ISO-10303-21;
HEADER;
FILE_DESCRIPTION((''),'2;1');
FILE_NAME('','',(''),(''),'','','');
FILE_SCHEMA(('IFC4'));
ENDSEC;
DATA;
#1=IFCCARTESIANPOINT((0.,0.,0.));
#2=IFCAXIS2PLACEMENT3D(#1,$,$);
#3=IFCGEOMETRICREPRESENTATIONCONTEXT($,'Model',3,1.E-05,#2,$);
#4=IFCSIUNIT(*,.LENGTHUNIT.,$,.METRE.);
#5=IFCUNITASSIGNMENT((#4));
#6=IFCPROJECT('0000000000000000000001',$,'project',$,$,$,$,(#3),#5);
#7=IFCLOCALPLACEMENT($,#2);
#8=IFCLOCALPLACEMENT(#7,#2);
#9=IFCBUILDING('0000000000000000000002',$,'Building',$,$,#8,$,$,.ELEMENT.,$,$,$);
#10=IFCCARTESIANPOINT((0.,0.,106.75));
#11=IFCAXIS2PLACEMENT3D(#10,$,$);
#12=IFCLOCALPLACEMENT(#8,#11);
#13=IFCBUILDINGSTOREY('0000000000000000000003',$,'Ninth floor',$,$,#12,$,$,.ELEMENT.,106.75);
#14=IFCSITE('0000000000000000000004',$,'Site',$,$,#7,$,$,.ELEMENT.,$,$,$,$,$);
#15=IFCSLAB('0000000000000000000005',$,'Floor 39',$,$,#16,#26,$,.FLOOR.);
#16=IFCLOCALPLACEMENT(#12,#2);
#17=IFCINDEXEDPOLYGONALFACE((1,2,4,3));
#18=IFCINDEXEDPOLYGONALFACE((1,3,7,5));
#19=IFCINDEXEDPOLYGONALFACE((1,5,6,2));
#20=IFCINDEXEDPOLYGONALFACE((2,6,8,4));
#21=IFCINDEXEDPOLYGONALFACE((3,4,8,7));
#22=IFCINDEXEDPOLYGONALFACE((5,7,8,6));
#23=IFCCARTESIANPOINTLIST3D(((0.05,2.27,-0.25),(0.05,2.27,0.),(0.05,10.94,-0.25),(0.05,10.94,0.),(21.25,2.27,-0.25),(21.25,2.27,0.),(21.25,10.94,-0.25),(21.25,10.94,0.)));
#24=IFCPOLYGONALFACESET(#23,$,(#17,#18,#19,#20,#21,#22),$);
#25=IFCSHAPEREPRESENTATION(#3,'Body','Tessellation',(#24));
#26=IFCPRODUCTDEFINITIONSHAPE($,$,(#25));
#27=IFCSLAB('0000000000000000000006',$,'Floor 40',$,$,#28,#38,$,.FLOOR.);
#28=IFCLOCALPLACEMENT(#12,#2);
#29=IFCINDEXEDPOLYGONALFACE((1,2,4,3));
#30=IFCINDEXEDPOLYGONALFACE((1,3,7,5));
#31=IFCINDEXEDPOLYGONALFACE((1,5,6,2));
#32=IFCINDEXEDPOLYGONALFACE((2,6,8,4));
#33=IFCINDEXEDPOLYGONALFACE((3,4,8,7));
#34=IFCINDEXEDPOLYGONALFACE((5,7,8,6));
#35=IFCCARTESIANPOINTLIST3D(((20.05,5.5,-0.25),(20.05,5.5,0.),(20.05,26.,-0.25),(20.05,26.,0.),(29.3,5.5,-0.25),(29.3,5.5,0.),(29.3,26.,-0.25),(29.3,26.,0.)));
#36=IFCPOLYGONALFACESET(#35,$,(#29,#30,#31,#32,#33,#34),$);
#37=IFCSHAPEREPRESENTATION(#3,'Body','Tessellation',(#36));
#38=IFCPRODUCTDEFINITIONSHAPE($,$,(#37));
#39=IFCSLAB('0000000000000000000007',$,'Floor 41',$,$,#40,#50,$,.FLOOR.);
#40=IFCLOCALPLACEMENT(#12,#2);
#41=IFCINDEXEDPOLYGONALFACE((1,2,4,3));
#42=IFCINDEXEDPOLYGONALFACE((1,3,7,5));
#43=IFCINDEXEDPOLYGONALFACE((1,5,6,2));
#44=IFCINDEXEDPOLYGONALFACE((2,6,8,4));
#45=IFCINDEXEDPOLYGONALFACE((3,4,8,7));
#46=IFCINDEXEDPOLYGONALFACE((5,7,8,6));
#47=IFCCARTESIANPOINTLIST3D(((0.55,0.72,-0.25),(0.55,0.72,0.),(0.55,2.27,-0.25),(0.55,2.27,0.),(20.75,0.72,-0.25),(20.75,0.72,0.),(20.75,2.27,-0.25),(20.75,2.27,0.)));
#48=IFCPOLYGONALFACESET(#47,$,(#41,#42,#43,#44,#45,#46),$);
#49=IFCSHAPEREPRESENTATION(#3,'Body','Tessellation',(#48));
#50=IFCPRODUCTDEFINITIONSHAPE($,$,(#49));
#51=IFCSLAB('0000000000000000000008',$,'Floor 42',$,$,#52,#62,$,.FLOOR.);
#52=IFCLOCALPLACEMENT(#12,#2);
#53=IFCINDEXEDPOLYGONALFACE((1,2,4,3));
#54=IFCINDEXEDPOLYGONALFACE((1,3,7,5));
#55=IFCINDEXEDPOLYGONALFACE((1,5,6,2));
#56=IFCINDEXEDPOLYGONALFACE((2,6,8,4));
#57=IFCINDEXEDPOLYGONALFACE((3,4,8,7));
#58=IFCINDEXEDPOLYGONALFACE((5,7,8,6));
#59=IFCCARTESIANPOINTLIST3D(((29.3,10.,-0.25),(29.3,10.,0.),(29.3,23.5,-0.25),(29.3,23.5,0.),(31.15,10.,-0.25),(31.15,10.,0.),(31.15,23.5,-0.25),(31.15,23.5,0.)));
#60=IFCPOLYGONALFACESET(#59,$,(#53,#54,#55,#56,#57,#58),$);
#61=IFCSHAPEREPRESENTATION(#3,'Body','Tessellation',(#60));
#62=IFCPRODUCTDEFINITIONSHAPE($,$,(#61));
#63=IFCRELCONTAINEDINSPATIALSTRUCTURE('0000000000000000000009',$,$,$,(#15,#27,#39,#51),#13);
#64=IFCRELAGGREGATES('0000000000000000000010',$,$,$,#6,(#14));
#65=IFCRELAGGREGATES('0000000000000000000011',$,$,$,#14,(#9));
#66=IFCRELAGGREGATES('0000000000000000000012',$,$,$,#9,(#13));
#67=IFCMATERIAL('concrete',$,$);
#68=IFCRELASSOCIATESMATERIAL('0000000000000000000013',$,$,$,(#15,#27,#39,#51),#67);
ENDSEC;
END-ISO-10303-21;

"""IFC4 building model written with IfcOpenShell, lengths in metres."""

from ifc_helpers import new_model, si_unit, frame, origin, place, context, project, spatial, polyline, outline, extrude, material, element, save


model = new_model("IFC4")

# Units and contexts
model_context = context("Model", 3, precision=1e-05, world=origin())
ifc_project = project(units=[si_unit("LENGTHUNIT", "METRE")], contexts=[model_context])

# Site, building, storey
site_placement = place(None, origin())
site = spatial("IfcSite", under=ifc_project, at=site_placement, Name="Site", CompositionType="ELEMENT")
building_placement = place(site_placement, origin())
building = spatial("IfcBuilding", under=site, at=building_placement, Name="Building", CompositionType="ELEMENT")
storey_placement = place(building_placement, frame((0.0, 0.0, 106.75)))
storey = spatial("IfcBuildingStorey", under=building, at=storey_placement, Name="Ninth floor", CompositionType="ELEMENT", Elevation=106.75)

# Slabs
ifc_material = material(Name="concrete")
slab_1_placement = place(storey_placement, frame((0.0, 0.0, -0.25), z_axis=(0.0, 0.0, 1.0), x_axis=(1.0, 0.0, 0.0)))
element("IfcSlab", 1, at=slab_1_placement, inside=storey, material=ifc_material, Name="Floor 39", PredefinedType="FLOOR", context=model_context, shape_type="SweptSolid", body=[
    extrude(outline(polyline([(0.05, 2.27), (21.25, 2.27), (21.25, 10.94), (0.05, 10.94), (0.05, 2.27)])), origin(), (0.0, 0.0, 1.0), 0.25),
])
slab_2_placement = place(storey_placement, frame((0.0, 0.0, -0.25), z_axis=(0.0, 0.0, 1.0), x_axis=(1.0, 0.0, 0.0)))
element("IfcSlab", 2, at=slab_2_placement, inside=storey, material=ifc_material, Name="Floor 40", PredefinedType="FLOOR", context=model_context, shape_type="SweptSolid", body=[
    extrude(outline(polyline([(20.05, 5.5), (29.3, 5.5), (29.3, 26.0), (20.05, 26.0), (20.05, 5.5)])), origin(), (0.0, 0.0, 1.0), 0.25),
])
slab_3_placement = place(storey_placement, frame((0.0, 0.0, -0.25), z_axis=(0.0, 0.0, 1.0), x_axis=(1.0, 0.0, 0.0)))
element("IfcSlab", 3, at=slab_3_placement, inside=storey, material=ifc_material, Name="Floor 41", PredefinedType="FLOOR", context=model_context, shape_type="SweptSolid", body=[
    extrude(outline(polyline([(0.55, 0.72), (20.75, 0.72), (20.75, 2.27), (0.55, 2.27), (0.55, 0.72)])), origin(), (0.0, 0.0, 1.0), 0.25),
])
slab_4_placement = place(storey_placement, frame((0.0, 0.0, -0.25), z_axis=(0.0, 0.0, 1.0), x_axis=(1.0, 0.0, 0.0)))
element("IfcSlab", 4, at=slab_4_placement, inside=storey, material=ifc_material, Name="Floor 42", PredefinedType="FLOOR", context=model_context, shape_type="SweptSolid", body=[
    extrude(outline(polyline([(29.3, 10.0), (31.15, 10.0), (31.15, 23.5), (29.3, 23.5), (29.3, 10.0)])), origin(), (0.0, 0.0, 1.0), 0.25),
])

save(model, "model.ifc")
